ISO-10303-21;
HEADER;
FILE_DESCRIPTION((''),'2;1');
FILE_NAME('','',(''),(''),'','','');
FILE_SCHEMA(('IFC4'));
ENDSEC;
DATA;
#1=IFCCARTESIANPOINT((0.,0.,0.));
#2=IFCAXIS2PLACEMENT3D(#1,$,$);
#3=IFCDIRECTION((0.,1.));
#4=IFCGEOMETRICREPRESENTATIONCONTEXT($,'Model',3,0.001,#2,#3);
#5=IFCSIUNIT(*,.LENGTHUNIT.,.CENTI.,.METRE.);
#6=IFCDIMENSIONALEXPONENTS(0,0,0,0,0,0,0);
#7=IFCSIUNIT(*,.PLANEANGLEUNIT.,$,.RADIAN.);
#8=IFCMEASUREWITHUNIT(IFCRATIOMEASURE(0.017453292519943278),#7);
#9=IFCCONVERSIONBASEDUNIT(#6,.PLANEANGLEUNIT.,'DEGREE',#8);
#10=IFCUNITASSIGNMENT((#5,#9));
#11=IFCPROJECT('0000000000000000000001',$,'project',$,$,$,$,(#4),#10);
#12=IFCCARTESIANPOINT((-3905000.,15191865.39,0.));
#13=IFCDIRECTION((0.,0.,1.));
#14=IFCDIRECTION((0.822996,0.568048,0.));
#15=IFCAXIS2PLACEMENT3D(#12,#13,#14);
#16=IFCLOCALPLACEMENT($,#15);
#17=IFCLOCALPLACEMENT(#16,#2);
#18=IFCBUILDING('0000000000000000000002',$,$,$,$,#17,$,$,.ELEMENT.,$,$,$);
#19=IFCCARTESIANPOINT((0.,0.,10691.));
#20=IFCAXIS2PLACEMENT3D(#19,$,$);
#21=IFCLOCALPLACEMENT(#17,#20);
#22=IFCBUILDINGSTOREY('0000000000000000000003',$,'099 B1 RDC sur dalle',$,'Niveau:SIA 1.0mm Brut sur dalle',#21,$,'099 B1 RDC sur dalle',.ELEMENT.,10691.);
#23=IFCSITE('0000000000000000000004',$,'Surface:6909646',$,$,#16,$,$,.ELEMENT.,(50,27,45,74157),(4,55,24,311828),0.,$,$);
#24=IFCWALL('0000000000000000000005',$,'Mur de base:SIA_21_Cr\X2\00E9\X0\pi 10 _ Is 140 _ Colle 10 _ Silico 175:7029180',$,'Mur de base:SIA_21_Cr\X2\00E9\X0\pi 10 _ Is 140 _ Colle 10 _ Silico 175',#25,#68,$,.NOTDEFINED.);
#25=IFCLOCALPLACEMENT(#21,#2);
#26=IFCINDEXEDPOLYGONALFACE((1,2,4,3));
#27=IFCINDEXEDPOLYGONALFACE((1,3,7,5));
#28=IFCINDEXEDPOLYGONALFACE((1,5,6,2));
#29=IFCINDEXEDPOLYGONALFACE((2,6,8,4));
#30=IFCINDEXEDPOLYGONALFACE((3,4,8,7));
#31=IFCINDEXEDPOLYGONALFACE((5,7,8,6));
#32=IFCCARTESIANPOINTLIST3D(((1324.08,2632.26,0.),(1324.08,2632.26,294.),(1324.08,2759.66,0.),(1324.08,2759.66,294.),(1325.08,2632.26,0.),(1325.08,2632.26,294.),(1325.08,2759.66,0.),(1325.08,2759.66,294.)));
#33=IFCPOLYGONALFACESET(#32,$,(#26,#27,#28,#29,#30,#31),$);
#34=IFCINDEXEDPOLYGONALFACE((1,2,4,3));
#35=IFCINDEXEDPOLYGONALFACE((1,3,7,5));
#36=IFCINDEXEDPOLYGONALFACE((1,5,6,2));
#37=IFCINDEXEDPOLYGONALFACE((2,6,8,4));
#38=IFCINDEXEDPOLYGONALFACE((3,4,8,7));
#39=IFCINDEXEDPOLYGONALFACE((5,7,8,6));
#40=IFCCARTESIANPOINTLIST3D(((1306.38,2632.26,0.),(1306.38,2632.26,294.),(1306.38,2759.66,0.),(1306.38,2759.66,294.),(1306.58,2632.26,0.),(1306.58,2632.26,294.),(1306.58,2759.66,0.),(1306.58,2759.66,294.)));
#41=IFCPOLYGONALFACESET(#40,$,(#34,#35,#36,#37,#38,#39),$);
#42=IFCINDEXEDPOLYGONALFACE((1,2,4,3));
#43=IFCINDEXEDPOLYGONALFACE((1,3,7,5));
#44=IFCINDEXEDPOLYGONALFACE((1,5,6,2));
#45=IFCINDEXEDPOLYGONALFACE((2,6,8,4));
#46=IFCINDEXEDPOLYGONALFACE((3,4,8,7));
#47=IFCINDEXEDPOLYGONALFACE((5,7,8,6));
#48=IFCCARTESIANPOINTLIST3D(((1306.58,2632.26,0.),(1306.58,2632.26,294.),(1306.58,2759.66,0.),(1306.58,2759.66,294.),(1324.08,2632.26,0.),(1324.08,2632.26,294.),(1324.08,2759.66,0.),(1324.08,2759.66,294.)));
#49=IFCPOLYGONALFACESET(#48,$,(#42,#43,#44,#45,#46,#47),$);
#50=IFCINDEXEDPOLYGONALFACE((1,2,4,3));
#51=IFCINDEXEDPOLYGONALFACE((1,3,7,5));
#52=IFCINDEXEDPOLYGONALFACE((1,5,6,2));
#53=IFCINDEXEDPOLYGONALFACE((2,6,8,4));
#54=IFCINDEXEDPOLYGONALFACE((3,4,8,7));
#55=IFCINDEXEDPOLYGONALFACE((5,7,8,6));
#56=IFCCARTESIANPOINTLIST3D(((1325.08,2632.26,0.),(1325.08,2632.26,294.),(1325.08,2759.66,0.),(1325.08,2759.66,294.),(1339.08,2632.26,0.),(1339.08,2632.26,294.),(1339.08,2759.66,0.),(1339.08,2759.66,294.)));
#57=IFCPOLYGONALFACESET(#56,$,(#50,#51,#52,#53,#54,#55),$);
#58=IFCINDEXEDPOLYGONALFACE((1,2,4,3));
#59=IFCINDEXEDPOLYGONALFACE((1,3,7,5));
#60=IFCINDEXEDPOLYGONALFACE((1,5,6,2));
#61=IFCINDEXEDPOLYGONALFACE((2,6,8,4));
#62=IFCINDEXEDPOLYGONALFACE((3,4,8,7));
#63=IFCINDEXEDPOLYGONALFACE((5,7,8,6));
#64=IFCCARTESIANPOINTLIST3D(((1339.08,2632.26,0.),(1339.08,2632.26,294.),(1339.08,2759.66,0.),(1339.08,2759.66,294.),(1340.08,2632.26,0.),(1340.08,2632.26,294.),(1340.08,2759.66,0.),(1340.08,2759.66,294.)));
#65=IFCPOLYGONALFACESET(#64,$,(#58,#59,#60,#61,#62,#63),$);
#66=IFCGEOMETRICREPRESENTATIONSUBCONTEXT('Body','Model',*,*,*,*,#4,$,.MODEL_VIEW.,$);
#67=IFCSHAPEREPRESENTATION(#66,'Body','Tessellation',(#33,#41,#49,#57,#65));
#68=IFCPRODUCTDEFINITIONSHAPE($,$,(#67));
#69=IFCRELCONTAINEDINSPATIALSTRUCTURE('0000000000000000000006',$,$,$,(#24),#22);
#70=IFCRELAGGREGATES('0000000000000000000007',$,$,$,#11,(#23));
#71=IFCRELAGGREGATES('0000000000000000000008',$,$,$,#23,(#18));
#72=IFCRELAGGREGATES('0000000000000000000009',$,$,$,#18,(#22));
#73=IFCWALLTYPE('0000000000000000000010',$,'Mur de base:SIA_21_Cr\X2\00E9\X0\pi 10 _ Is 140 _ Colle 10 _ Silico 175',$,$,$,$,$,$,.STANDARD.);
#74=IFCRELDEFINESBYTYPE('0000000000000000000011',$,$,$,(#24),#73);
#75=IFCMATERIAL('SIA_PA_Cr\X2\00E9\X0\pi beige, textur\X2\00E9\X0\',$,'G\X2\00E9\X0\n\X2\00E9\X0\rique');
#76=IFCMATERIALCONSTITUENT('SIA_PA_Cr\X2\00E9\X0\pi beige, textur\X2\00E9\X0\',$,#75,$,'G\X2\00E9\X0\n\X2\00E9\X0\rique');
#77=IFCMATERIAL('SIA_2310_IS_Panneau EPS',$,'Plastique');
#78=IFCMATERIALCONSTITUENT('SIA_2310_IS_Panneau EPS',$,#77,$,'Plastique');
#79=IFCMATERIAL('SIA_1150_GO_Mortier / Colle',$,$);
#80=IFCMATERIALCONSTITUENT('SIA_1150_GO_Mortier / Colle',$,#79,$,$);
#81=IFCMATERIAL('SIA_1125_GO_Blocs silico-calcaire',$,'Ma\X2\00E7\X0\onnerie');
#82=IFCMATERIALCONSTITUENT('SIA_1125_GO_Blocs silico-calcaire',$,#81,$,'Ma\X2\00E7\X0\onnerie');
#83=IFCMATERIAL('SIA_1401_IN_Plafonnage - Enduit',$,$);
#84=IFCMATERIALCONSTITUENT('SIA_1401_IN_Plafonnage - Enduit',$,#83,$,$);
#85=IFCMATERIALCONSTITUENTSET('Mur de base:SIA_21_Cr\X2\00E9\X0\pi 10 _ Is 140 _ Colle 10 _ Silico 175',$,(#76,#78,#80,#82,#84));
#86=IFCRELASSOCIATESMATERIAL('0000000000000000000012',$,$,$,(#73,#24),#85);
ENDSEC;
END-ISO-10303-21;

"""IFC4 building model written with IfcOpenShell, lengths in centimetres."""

from ifc_helpers import new_model, entity, si_unit, converted_unit, direction, frame, origin, place, context, subcontext, project, spatial, indexed_curve, outline, extrude, material, constituent, constituent_set, type_object, element, save


model = new_model("IFC4")

# Units and contexts
model_context = context("Model", 3, precision=0.001, world=origin(), true_north=direction((0.0, 1.0)))
body_context = subcontext(model_context, "Body", "Model", "MODEL_VIEW")
ifc_project = project(units=[si_unit("LENGTHUNIT", "METRE", prefix="CENTI"), converted_unit("PLANEANGLEUNIT", "DEGREE", entity("IfcRatioMeasure", 0.017453292519943278), si_unit("PLANEANGLEUNIT", "RADIAN"), dimensions=[0, 0, 0, 0, 0, 0, 0])], contexts=[model_context])

# Site, building, storey
site_placement = place(None, frame((-3905000.0, 15191865.39, 0.0), z_axis=(0.0, 0.0, 1.0), x_axis=(0.822996, 0.568048, 0.0)))
site = spatial("IfcSite", under=ifc_project, at=site_placement, Name="Surface:6909646", CompositionType="ELEMENT", RefLatitude=(50, 27, 45, 74157), RefLongitude=(4, 55, 24, 311828), RefElevation=0.0)
building_placement = place(site_placement, origin())
building = spatial("IfcBuilding", under=site, at=building_placement, CompositionType="ELEMENT")
storey_placement = place(building_placement, frame((0.0, 0.0, 10691.0)))
storey = spatial("IfcBuildingStorey", under=building, at=storey_placement, Name="099 B1 RDC sur dalle", ObjectType="Niveau:SIA 1.0mm Brut sur dalle", LongName="099 B1 RDC sur dalle", CompositionType="ELEMENT", Elevation=10691.0)

# Wall
ifc_material_1 = material(Name="SIA_PA_Crépi beige, texturé", Category="Générique")
ifc_constituent_1 = constituent(ifc_material_1, Name="SIA_PA_Crépi beige, texturé", Category="Générique")
ifc_material_2 = material(Name="SIA_2310_IS_Panneau EPS", Category="Plastique")
ifc_constituent_2 = constituent(ifc_material_2, Name="SIA_2310_IS_Panneau EPS", Category="Plastique")
ifc_material_3 = material(Name="SIA_1150_GO_Mortier / Colle")
ifc_constituent_3 = constituent(ifc_material_3, Name="SIA_1150_GO_Mortier / Colle")
ifc_material_4 = material(Name="SIA_1125_GO_Blocs silico-calcaire", Category="Maçonnerie")
ifc_constituent_4 = constituent(ifc_material_4, Name="SIA_1125_GO_Blocs silico-calcaire", Category="Maçonnerie")
ifc_material_5 = material(Name="SIA_1401_IN_Plafonnage - Enduit")
ifc_constituent_5 = constituent(ifc_material_5, Name="SIA_1401_IN_Plafonnage - Enduit")
ifc_constituent_set = constituent_set(constituents=[ifc_constituent_1, ifc_constituent_2, ifc_constituent_3, ifc_constituent_4, ifc_constituent_5], Name="Mur de base:SIA_21_Crépi 10 _ Is 140 _ Colle 10 _ Silico 175")
wall_type_1 = type_object("IfcWallType", Name="Mur de base:SIA_21_Crépi 10 _ Is 140 _ Colle 10 _ Silico 175", PredefinedType="STANDARD", material=ifc_constituent_set)
wall_1_placement = place(storey_placement, frame((1323.23, 2759.66, 0.0), z_axis=(0.0, 0.0, 1.0), x_axis=(0.0, -1.0, 0.0)))
element("IfcWall", 1, at=wall_1_placement, inside=storey, type_object=wall_type_1, material=ifc_constituent_set, Name="Mur de base:SIA_21_Crépi 10 _ Is 140 _ Colle 10 _ Silico 175:7029180", ObjectType="Mur de base:SIA_21_Crépi 10 _ Is 140 _ Colle 10 _ Silico 175", PredefinedType="NOTDEFINED", context=body_context, shape_type="SweptSolid", body=[
    extrude(outline(indexed_curve([(-147.0, -63.7), (147.0, -63.7), (147.0, 63.7), (-147.0, 63.7), (-147.0, -63.7)], self_intersect=False)), frame((63.7, 0.85, 147.0), z_axis=(0.0, 1.0, 0.0), x_axis=(0.0, 0.0, 1.0)), (0.0, 0.0, 1.0), 1.0),
    extrude(outline(indexed_curve([(-147.0, -63.7), (147.0, -63.7), (147.0, 63.7), (-147.0, 63.7), (-147.0, -63.7)], self_intersect=False)), frame((63.7, -16.85, 147.0), z_axis=(0.0, 1.0, 0.0), x_axis=(0.0, 0.0, 1.0)), (0.0, 0.0, 1.0), 0.2),
    extrude(outline(indexed_curve([(-147.0, -63.7), (147.0, -63.7), (147.0, 63.7), (-147.0, 63.7), (-147.0, -63.7)], self_intersect=False)), frame((63.7, -16.65, 147.0), z_axis=(0.0, 1.0, 0.0), x_axis=(0.0, 0.0, 1.0)), (0.0, 0.0, 1.0), 17.5),
    extrude(outline(indexed_curve([(-147.0, -63.7), (147.0, -63.7), (147.0, 63.7), (-147.0, 63.7), (-147.0, -63.7)], self_intersect=False)), frame((63.7, 1.85, 147.0), z_axis=(0.0, 1.0, 0.0), x_axis=(0.0, 0.0, 1.0)), (0.0, 0.0, 1.0), 14.0),
    extrude(outline(indexed_curve([(-147.0, -63.7), (147.0, -63.7), (147.0, 63.7), (-147.0, 63.7), (-147.0, -63.7)], self_intersect=False)), frame((63.7, 15.85, 147.0), z_axis=(0.0, 1.0, 0.0), x_axis=(0.0, 0.0, 1.0)), (0.0, 0.0, 1.0), 1.0),
])

save(model, "model.ifc")
